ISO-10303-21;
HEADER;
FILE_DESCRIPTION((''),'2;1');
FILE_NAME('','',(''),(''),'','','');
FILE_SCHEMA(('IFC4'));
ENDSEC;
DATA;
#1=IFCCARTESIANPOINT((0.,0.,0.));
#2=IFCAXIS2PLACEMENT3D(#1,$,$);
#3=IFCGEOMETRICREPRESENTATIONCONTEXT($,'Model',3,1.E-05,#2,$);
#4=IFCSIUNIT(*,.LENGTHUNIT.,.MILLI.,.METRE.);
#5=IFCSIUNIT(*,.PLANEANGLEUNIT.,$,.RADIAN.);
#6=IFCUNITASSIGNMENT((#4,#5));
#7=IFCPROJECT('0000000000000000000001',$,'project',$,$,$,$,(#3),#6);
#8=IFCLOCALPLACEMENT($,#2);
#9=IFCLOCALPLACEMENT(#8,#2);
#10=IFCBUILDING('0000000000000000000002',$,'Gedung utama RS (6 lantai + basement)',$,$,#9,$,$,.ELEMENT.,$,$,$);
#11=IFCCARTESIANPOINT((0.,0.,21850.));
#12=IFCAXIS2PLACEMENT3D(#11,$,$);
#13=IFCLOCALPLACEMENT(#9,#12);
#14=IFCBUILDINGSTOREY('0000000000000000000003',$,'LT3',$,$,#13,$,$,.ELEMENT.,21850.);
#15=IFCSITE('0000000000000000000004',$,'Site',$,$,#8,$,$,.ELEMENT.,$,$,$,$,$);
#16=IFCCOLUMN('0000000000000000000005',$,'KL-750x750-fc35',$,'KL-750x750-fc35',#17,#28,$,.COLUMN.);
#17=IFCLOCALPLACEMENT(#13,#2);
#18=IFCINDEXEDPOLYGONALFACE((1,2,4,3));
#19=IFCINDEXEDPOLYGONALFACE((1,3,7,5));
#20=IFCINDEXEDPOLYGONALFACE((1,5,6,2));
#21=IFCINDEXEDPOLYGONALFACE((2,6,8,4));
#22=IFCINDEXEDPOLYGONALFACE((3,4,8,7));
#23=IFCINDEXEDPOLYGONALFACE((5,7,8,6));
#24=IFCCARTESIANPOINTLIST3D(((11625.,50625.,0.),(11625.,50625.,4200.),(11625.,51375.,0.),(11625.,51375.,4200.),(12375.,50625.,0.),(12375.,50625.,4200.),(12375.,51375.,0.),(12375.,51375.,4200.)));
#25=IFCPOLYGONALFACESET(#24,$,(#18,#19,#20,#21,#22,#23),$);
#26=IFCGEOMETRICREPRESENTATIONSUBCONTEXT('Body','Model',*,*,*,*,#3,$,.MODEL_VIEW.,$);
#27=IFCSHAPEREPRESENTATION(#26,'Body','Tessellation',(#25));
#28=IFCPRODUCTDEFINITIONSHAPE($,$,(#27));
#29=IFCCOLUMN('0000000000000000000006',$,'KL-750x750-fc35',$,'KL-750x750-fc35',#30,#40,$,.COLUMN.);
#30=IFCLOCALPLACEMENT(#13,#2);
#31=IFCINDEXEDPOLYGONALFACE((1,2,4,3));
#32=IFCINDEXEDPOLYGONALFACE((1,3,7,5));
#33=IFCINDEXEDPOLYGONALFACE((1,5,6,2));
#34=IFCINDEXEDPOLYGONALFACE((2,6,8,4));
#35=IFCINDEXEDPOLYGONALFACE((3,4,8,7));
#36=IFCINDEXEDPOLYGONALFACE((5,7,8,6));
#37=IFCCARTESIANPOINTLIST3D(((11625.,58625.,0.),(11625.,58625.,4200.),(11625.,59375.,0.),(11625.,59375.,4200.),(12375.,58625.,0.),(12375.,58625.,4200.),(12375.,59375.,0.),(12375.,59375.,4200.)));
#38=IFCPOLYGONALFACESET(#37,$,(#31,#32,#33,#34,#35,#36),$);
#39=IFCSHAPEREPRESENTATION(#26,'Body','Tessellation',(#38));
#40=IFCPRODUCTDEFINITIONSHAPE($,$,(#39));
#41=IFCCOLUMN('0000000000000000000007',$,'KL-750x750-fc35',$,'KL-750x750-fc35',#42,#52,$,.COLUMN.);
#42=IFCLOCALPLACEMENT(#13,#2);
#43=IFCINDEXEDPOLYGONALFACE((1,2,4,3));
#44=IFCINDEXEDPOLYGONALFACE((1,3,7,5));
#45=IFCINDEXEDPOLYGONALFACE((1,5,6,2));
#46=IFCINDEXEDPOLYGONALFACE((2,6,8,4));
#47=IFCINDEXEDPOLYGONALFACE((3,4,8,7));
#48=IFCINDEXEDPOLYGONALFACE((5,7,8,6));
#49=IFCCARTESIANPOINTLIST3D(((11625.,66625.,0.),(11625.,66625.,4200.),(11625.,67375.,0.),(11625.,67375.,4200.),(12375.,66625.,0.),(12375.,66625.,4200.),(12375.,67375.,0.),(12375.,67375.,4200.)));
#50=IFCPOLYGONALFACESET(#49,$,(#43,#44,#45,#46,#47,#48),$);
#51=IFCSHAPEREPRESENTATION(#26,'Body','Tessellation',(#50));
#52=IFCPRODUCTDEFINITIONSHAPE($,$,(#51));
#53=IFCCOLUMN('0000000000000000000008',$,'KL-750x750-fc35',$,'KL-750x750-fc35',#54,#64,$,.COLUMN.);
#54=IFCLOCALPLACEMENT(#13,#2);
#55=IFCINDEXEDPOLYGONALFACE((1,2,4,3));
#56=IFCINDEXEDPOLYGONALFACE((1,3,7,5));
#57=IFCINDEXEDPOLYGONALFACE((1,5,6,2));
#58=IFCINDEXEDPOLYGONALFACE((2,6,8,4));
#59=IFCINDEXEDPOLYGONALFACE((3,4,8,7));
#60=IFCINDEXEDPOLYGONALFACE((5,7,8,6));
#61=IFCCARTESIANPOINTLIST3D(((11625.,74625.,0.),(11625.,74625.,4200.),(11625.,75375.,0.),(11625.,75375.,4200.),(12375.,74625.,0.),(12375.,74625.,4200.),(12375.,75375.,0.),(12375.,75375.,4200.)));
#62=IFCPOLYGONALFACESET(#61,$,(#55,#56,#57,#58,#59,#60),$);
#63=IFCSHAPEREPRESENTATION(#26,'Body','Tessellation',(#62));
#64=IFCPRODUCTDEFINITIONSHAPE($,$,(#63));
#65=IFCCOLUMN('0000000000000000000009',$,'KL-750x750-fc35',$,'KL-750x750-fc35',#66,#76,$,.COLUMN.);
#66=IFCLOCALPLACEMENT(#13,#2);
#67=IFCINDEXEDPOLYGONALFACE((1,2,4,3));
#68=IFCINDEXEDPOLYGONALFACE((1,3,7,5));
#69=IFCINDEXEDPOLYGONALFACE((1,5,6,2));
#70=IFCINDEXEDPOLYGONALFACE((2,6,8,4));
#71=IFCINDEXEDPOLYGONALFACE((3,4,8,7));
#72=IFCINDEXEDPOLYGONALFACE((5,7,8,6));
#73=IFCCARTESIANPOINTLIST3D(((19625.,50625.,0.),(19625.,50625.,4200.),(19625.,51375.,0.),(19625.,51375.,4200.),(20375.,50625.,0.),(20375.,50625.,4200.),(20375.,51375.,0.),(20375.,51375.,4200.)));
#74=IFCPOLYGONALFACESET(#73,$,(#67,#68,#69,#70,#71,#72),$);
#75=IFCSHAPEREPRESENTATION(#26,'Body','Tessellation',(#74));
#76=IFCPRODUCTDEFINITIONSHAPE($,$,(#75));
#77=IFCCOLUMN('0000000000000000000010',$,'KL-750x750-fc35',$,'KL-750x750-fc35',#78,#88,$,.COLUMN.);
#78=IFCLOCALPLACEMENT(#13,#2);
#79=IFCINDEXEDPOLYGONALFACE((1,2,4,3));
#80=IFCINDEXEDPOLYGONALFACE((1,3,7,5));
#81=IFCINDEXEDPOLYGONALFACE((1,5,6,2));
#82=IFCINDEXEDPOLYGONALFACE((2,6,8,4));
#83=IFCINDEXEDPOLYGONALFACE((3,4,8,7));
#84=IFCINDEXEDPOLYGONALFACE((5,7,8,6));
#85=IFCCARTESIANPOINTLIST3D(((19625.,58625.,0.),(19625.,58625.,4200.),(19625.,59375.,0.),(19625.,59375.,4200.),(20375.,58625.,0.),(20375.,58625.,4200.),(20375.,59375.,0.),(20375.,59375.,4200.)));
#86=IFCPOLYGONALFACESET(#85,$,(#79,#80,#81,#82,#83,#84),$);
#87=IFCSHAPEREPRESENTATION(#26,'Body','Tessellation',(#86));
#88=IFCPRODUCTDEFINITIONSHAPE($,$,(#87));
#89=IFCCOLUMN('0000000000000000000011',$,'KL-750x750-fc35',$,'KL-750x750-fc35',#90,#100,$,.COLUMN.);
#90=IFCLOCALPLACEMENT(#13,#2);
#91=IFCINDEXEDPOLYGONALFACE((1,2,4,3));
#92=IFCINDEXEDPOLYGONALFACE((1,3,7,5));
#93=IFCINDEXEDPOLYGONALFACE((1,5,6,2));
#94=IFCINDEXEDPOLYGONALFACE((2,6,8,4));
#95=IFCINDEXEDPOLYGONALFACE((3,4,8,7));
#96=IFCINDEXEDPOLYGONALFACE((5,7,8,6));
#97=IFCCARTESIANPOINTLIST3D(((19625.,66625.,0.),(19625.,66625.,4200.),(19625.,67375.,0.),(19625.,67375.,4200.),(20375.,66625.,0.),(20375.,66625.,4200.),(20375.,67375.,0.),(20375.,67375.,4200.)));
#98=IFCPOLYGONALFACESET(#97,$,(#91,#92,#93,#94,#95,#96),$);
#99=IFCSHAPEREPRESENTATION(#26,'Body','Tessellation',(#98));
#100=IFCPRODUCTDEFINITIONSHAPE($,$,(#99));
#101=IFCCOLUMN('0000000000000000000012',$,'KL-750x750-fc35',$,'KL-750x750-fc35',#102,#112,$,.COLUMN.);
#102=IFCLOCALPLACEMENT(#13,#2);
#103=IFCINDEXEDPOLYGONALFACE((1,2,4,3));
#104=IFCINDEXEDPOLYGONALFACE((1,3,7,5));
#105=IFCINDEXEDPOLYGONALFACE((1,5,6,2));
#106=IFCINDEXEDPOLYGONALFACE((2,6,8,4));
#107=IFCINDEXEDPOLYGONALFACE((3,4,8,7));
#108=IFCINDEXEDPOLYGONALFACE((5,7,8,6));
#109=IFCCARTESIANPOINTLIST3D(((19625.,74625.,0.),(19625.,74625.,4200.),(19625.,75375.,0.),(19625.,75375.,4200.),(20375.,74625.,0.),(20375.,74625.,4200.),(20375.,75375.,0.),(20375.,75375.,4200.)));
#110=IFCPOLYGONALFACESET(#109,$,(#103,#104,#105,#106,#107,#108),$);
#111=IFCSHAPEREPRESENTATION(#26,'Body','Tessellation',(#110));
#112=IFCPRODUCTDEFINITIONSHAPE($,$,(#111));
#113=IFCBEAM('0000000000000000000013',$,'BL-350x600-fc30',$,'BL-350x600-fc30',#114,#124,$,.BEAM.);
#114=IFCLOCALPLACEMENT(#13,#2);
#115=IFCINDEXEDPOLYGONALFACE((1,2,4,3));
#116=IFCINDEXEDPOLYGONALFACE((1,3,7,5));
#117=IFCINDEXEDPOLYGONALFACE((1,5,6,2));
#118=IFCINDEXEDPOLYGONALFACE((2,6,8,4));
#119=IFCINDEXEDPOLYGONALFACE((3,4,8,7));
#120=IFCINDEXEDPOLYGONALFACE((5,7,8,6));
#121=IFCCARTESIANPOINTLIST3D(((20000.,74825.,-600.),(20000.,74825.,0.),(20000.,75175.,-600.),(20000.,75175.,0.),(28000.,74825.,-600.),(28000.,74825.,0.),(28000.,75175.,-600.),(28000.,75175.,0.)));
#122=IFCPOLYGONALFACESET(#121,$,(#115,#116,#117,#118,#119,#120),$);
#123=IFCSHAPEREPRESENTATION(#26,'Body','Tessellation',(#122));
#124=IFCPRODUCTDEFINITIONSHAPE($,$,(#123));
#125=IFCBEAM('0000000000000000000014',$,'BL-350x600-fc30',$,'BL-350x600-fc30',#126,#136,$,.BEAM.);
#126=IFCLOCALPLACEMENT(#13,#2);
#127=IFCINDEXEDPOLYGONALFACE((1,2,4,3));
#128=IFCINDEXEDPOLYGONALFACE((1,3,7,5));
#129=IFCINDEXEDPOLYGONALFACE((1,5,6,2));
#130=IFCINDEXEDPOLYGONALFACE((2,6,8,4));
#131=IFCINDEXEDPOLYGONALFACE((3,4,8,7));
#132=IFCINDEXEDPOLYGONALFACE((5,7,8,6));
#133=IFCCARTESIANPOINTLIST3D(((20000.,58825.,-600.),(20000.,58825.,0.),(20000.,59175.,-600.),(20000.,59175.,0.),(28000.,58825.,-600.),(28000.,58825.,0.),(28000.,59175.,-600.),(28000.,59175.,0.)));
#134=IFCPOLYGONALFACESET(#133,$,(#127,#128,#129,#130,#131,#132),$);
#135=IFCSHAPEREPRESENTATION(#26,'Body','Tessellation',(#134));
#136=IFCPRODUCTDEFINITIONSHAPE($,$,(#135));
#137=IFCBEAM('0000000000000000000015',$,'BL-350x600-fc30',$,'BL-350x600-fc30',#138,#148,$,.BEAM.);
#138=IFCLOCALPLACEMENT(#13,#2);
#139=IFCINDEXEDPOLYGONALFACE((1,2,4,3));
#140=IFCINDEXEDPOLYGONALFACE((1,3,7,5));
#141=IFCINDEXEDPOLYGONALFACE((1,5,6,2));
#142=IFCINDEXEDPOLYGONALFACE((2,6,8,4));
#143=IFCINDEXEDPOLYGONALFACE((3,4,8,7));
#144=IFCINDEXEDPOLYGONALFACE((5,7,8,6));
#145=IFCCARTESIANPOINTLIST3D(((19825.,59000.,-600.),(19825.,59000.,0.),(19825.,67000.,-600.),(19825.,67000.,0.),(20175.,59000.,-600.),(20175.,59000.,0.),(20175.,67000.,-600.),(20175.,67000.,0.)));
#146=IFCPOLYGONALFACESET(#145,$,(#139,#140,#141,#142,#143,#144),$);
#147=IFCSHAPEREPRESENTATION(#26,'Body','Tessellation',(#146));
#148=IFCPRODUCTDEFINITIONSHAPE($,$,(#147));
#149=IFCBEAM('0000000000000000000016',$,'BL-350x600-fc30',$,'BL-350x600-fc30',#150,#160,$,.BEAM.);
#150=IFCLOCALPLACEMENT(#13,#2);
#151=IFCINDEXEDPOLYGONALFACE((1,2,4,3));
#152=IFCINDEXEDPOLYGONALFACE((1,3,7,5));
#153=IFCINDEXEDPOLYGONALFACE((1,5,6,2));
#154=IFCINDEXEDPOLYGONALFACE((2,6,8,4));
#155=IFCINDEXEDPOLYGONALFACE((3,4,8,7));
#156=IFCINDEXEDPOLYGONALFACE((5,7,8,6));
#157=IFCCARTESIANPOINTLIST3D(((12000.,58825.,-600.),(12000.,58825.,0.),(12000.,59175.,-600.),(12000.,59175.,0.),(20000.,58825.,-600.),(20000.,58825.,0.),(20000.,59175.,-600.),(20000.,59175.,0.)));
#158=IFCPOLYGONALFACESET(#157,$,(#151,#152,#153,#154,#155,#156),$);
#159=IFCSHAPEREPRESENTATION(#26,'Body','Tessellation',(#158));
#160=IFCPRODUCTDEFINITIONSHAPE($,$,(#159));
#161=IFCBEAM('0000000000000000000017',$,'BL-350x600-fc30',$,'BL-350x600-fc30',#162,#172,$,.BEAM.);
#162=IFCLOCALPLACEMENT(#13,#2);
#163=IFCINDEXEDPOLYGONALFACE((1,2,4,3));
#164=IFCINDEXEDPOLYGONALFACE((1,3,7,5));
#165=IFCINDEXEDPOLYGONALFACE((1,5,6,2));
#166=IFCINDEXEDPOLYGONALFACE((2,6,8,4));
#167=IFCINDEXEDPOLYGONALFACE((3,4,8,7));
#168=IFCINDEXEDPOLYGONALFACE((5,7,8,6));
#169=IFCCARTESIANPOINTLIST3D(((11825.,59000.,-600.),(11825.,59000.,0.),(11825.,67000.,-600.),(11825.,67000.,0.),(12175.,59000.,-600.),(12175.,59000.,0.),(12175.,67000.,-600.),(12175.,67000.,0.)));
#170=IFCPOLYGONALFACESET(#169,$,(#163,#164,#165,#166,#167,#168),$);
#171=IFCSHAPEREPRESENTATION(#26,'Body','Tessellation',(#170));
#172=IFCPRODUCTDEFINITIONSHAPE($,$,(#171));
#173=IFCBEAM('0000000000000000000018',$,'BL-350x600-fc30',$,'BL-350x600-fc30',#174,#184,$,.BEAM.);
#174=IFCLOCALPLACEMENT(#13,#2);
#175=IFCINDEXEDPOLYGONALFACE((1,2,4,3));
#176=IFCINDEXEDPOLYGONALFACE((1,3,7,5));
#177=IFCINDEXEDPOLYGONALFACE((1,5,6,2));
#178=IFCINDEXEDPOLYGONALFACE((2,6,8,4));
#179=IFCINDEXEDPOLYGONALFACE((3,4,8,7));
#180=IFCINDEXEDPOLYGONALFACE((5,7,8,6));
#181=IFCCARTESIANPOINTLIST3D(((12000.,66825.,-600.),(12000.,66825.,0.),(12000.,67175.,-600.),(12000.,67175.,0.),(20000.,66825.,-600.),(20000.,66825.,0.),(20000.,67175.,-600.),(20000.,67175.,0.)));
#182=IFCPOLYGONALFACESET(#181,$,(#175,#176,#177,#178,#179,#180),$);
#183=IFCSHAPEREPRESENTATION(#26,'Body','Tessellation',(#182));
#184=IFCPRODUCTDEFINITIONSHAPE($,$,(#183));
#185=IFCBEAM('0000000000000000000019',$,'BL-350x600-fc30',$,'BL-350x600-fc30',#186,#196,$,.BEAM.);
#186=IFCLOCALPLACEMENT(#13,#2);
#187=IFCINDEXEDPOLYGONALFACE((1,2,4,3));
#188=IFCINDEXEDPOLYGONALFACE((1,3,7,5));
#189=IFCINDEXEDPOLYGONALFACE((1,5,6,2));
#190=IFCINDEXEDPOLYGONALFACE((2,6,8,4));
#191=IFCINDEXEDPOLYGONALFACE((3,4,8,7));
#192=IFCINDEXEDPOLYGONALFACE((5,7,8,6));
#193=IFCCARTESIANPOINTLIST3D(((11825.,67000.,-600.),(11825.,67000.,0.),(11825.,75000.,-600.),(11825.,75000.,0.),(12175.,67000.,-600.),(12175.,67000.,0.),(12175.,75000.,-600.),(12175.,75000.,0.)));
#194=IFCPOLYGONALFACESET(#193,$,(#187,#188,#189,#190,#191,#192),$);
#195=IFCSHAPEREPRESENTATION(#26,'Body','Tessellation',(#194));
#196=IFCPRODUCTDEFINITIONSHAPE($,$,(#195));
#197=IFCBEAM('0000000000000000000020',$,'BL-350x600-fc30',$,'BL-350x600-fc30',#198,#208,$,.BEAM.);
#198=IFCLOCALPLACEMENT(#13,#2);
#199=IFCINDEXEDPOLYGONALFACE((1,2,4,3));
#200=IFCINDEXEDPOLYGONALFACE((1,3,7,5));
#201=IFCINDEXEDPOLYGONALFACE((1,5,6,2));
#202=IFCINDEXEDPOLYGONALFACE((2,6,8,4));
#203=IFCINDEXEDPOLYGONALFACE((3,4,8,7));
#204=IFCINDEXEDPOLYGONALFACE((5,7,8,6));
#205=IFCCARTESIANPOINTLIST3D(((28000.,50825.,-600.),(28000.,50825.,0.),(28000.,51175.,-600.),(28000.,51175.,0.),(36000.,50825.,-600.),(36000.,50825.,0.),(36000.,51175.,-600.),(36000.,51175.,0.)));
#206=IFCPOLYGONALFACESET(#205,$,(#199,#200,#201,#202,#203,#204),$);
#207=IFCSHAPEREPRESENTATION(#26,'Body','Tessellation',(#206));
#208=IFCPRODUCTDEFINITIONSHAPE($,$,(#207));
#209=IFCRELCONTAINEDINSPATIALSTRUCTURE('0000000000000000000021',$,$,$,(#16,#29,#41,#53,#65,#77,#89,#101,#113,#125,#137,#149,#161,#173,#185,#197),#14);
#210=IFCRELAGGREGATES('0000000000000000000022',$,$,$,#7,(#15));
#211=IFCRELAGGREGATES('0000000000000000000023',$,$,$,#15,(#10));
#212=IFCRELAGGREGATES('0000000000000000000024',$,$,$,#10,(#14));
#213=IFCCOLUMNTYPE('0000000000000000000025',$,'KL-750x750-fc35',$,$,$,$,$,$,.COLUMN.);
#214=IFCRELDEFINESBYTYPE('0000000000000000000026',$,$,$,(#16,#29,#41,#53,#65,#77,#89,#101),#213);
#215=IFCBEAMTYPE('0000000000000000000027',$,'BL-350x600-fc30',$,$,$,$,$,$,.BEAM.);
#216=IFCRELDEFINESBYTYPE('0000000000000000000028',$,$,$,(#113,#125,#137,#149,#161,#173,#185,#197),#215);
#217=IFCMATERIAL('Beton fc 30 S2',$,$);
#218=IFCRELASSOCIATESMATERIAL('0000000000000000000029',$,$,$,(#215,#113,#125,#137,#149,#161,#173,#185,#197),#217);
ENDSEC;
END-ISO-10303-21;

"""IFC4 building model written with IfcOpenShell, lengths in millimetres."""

from ifc_helpers import new_model, si_unit, frame, origin, origin_2d, place, context, subcontext, project, spatial, rectangle, extrude, material, material_profile, profile_set, profile_usage, type_object, element, save


model = new_model("IFC4")

# Units and contexts
model_context = context("Model", 3, precision=1e-05, world=origin())
body_context = subcontext(model_context, "Body", "Model", "MODEL_VIEW")
ifc_project = project(units=[si_unit("LENGTHUNIT", "METRE", prefix="MILLI"), si_unit("PLANEANGLEUNIT", "RADIAN")], contexts=[model_context])

# Site, building, storey
site_placement = place(None, origin())
site = spatial("IfcSite", under=ifc_project, at=site_placement, Name="Site", CompositionType="ELEMENT")
building_placement = place(site_placement, origin())
building = spatial("IfcBuilding", under=site, at=building_placement, Name="Gedung utama RS (6 lantai + basement)", CompositionType="ELEMENT")
storey_placement = place(building_placement, frame((0.0, 0.0, 21850.0)))
storey = spatial("IfcBuildingStorey", under=building, at=storey_placement, Name="LT3", CompositionType="ELEMENT", Elevation=21850.0)

# Columns
ifc_material_profile_1 = material_profile(None, rectangle(XDim=750.0, YDim=750.0, at=origin_2d()), Name="KL-750x750-fc35")
ifc_profile_set_1 = profile_set([ifc_material_profile_1], Name="KL-750x750-fc35")
ifc_profile_usage_1 = profile_usage(ifc_profile_set_1, cardinal=5)
column_type = type_object("IfcColumnType", Name="KL-750x750-fc35", PredefinedType="COLUMN", material=ifc_profile_set_1)
for number, where, z_axis, x_axis, name in (
    (1, (12000.0, 51000.0, 0.0), (0.0, 0.0, 1.0), (1.0, 0.0, 0.0), "KL-750x750-fc35"),
    (2, (12000.0, 59000.0, 0.0), (0.0, 0.0, 1.0), (1.0, 0.0, 0.0), "KL-750x750-fc35"),
    (3, (12000.0, 67000.0, 0.0), (0.0, 0.0, 1.0), (1.0, 0.0, 0.0), "KL-750x750-fc35"),
    (4, (12000.0, 75000.0, 0.0), (0.0, 0.0, 1.0), (1.0, 0.0, 0.0), "KL-750x750-fc35"),
    (5, (20000.0, 51000.0, 0.0), (0.0, 0.0, 1.0), (1.0, 0.0, 0.0), "KL-750x750-fc35"),
    (6, (20000.0, 59000.0, 0.0), (0.0, 0.0, 1.0), (1.0, 0.0, 0.0), "KL-750x750-fc35"),
    (7, (20000.0, 67000.0, 0.0), (0.0, 0.0, 1.0), (1.0, 0.0, 0.0), "KL-750x750-fc35"),
    (8, (20000.0, 75000.0, 0.0), (0.0, 0.0, 1.0), (1.0, 0.0, 0.0), "KL-750x750-fc35"),
):
    element("IfcColumn", number, at=place(storey_placement, frame(where, z_axis=z_axis, x_axis=x_axis)), inside=storey, type_object=column_type, material=ifc_profile_usage_1, Name=name, ObjectType="KL-750x750-fc35", PredefinedType="COLUMN", context=body_context, shape_type="SweptSolid", body=[
        extrude(rectangle(XDim=750.0, YDim=750.0, at=origin_2d()), origin(), (0.0, 0.0, 1.0), 4200.0),
    ])

# Beams
ifc_material_1 = material(Name="Beton fc 30 S2")
ifc_material_profile_2 = material_profile(ifc_material_1, rectangle(XDim=350.0, YDim=600.0, at=origin_2d()), Name="BL-350x600-fc30")
ifc_profile_set_2 = profile_set([ifc_material_profile_2], Name="BL-350x600-fc30")
ifc_profile_usage_2 = profile_usage(ifc_profile_set_2, cardinal=8)
beam_type = type_object("IfcBeamType", Name="BL-350x600-fc30", PredefinedType="BEAM", material=ifc_profile_set_2)
for number, where, name in (
    (9, (20000.0, 75000.0, -300.0), "BL-350x600-fc30"),
    (10, (20000.0, 59000.0, -300.0), "BL-350x600-fc30"),
):
    element("IfcBeam", number, at=place(storey_placement, frame(where)), inside=storey, type_object=beam_type, material=ifc_profile_usage_2, Name=name, ObjectType="BL-350x600-fc30", PredefinedType="BEAM", context=body_context, shape_type="SweptSolid", body=[
        extrude(rectangle(XDim=350.0, YDim=600.0, at=origin_2d()), frame((0.0, 0.0, 0.0), z_axis=(1.0, 0.0, 0.0), x_axis=(0.0, 1.0, 0.0)), (0.0, 0.0, 1.0), 8000.0),
    ])
beam_1_placement = place(storey_placement, frame((20000.0, 59000.0, -300.0)))
element("IfcBeam", 11, at=beam_1_placement, inside=storey, type_object=beam_type, material=ifc_profile_usage_2, Name="BL-350x600-fc30", ObjectType="BL-350x600-fc30", PredefinedType="BEAM", context=body_context, shape_type="SweptSolid", body=[
    extrude(rectangle(XDim=350.0, YDim=600.0, at=origin_2d()), frame((0.0, 0.0, 0.0), z_axis=(0.0, 1.0, 0.0), x_axis=(-1.0, 0.0, 0.0)), (0.0, 0.0, 1.0), 8000.0),
])
beam_2_placement = place(storey_placement, frame((12000.0, 59000.0, -300.0)))
element("IfcBeam", 12, at=beam_2_placement, inside=storey, type_object=beam_type, material=ifc_profile_usage_2, Name="BL-350x600-fc30", ObjectType="BL-350x600-fc30", PredefinedType="BEAM", context=body_context, shape_type="SweptSolid", body=[
    extrude(rectangle(XDim=350.0, YDim=600.0, at=origin_2d()), frame((0.0, 0.0, 0.0), z_axis=(1.0, 0.0, 0.0), x_axis=(0.0, 1.0, 0.0)), (0.0, 0.0, 1.0), 8000.0),
])
beam_3_placement = place(storey_placement, frame((12000.0, 59000.0, -300.0)))
element("IfcBeam", 13, at=beam_3_placement, inside=storey, type_object=beam_type, material=ifc_profile_usage_2, Name="BL-350x600-fc30", ObjectType="BL-350x600-fc30", PredefinedType="BEAM", context=body_context, shape_type="SweptSolid", body=[
    extrude(rectangle(XDim=350.0, YDim=600.0, at=origin_2d()), frame((0.0, 0.0, 0.0), z_axis=(0.0, 1.0, 0.0), x_axis=(-1.0, 0.0, 0.0)), (0.0, 0.0, 1.0), 8000.0),
])
beam_4_placement = place(storey_placement, frame((12000.0, 67000.0, -300.0)))
element("IfcBeam", 14, at=beam_4_placement, inside=storey, type_object=beam_type, material=ifc_profile_usage_2, Name="BL-350x600-fc30", ObjectType="BL-350x600-fc30", PredefinedType="BEAM", context=body_context, shape_type="SweptSolid", body=[
    extrude(rectangle(XDim=350.0, YDim=600.0, at=origin_2d()), frame((0.0, 0.0, 0.0), z_axis=(1.0, 0.0, 0.0), x_axis=(0.0, 1.0, 0.0)), (0.0, 0.0, 1.0), 8000.0),
])
beam_5_placement = place(storey_placement, frame((12000.0, 67000.0, -300.0)))
element("IfcBeam", 15, at=beam_5_placement, inside=storey, type_object=beam_type, material=ifc_profile_usage_2, Name="BL-350x600-fc30", ObjectType="BL-350x600-fc30", PredefinedType="BEAM", context=body_context, shape_type="SweptSolid", body=[
    extrude(rectangle(XDim=350.0, YDim=600.0, at=origin_2d()), frame((0.0, 0.0, 0.0), z_axis=(0.0, 1.0, 0.0), x_axis=(-1.0, 0.0, 0.0)), (0.0, 0.0, 1.0), 8000.0),
])
beam_6_placement = place(storey_placement, frame((28000.0, 51000.0, -300.0)))
element("IfcBeam", 16, at=beam_6_placement, inside=storey, type_object=beam_type, material=ifc_profile_usage_2, Name="BL-350x600-fc30", ObjectType="BL-350x600-fc30", PredefinedType="BEAM", context=body_context, shape_type="SweptSolid", body=[
    extrude(rectangle(XDim=350.0, YDim=600.0, at=origin_2d()), frame((0.0, 0.0, 0.0), z_axis=(1.0, 0.0, 0.0), x_axis=(0.0, 1.0, 0.0)), (0.0, 0.0, 1.0), 8000.0),
])

save(model, "model.ifc")
